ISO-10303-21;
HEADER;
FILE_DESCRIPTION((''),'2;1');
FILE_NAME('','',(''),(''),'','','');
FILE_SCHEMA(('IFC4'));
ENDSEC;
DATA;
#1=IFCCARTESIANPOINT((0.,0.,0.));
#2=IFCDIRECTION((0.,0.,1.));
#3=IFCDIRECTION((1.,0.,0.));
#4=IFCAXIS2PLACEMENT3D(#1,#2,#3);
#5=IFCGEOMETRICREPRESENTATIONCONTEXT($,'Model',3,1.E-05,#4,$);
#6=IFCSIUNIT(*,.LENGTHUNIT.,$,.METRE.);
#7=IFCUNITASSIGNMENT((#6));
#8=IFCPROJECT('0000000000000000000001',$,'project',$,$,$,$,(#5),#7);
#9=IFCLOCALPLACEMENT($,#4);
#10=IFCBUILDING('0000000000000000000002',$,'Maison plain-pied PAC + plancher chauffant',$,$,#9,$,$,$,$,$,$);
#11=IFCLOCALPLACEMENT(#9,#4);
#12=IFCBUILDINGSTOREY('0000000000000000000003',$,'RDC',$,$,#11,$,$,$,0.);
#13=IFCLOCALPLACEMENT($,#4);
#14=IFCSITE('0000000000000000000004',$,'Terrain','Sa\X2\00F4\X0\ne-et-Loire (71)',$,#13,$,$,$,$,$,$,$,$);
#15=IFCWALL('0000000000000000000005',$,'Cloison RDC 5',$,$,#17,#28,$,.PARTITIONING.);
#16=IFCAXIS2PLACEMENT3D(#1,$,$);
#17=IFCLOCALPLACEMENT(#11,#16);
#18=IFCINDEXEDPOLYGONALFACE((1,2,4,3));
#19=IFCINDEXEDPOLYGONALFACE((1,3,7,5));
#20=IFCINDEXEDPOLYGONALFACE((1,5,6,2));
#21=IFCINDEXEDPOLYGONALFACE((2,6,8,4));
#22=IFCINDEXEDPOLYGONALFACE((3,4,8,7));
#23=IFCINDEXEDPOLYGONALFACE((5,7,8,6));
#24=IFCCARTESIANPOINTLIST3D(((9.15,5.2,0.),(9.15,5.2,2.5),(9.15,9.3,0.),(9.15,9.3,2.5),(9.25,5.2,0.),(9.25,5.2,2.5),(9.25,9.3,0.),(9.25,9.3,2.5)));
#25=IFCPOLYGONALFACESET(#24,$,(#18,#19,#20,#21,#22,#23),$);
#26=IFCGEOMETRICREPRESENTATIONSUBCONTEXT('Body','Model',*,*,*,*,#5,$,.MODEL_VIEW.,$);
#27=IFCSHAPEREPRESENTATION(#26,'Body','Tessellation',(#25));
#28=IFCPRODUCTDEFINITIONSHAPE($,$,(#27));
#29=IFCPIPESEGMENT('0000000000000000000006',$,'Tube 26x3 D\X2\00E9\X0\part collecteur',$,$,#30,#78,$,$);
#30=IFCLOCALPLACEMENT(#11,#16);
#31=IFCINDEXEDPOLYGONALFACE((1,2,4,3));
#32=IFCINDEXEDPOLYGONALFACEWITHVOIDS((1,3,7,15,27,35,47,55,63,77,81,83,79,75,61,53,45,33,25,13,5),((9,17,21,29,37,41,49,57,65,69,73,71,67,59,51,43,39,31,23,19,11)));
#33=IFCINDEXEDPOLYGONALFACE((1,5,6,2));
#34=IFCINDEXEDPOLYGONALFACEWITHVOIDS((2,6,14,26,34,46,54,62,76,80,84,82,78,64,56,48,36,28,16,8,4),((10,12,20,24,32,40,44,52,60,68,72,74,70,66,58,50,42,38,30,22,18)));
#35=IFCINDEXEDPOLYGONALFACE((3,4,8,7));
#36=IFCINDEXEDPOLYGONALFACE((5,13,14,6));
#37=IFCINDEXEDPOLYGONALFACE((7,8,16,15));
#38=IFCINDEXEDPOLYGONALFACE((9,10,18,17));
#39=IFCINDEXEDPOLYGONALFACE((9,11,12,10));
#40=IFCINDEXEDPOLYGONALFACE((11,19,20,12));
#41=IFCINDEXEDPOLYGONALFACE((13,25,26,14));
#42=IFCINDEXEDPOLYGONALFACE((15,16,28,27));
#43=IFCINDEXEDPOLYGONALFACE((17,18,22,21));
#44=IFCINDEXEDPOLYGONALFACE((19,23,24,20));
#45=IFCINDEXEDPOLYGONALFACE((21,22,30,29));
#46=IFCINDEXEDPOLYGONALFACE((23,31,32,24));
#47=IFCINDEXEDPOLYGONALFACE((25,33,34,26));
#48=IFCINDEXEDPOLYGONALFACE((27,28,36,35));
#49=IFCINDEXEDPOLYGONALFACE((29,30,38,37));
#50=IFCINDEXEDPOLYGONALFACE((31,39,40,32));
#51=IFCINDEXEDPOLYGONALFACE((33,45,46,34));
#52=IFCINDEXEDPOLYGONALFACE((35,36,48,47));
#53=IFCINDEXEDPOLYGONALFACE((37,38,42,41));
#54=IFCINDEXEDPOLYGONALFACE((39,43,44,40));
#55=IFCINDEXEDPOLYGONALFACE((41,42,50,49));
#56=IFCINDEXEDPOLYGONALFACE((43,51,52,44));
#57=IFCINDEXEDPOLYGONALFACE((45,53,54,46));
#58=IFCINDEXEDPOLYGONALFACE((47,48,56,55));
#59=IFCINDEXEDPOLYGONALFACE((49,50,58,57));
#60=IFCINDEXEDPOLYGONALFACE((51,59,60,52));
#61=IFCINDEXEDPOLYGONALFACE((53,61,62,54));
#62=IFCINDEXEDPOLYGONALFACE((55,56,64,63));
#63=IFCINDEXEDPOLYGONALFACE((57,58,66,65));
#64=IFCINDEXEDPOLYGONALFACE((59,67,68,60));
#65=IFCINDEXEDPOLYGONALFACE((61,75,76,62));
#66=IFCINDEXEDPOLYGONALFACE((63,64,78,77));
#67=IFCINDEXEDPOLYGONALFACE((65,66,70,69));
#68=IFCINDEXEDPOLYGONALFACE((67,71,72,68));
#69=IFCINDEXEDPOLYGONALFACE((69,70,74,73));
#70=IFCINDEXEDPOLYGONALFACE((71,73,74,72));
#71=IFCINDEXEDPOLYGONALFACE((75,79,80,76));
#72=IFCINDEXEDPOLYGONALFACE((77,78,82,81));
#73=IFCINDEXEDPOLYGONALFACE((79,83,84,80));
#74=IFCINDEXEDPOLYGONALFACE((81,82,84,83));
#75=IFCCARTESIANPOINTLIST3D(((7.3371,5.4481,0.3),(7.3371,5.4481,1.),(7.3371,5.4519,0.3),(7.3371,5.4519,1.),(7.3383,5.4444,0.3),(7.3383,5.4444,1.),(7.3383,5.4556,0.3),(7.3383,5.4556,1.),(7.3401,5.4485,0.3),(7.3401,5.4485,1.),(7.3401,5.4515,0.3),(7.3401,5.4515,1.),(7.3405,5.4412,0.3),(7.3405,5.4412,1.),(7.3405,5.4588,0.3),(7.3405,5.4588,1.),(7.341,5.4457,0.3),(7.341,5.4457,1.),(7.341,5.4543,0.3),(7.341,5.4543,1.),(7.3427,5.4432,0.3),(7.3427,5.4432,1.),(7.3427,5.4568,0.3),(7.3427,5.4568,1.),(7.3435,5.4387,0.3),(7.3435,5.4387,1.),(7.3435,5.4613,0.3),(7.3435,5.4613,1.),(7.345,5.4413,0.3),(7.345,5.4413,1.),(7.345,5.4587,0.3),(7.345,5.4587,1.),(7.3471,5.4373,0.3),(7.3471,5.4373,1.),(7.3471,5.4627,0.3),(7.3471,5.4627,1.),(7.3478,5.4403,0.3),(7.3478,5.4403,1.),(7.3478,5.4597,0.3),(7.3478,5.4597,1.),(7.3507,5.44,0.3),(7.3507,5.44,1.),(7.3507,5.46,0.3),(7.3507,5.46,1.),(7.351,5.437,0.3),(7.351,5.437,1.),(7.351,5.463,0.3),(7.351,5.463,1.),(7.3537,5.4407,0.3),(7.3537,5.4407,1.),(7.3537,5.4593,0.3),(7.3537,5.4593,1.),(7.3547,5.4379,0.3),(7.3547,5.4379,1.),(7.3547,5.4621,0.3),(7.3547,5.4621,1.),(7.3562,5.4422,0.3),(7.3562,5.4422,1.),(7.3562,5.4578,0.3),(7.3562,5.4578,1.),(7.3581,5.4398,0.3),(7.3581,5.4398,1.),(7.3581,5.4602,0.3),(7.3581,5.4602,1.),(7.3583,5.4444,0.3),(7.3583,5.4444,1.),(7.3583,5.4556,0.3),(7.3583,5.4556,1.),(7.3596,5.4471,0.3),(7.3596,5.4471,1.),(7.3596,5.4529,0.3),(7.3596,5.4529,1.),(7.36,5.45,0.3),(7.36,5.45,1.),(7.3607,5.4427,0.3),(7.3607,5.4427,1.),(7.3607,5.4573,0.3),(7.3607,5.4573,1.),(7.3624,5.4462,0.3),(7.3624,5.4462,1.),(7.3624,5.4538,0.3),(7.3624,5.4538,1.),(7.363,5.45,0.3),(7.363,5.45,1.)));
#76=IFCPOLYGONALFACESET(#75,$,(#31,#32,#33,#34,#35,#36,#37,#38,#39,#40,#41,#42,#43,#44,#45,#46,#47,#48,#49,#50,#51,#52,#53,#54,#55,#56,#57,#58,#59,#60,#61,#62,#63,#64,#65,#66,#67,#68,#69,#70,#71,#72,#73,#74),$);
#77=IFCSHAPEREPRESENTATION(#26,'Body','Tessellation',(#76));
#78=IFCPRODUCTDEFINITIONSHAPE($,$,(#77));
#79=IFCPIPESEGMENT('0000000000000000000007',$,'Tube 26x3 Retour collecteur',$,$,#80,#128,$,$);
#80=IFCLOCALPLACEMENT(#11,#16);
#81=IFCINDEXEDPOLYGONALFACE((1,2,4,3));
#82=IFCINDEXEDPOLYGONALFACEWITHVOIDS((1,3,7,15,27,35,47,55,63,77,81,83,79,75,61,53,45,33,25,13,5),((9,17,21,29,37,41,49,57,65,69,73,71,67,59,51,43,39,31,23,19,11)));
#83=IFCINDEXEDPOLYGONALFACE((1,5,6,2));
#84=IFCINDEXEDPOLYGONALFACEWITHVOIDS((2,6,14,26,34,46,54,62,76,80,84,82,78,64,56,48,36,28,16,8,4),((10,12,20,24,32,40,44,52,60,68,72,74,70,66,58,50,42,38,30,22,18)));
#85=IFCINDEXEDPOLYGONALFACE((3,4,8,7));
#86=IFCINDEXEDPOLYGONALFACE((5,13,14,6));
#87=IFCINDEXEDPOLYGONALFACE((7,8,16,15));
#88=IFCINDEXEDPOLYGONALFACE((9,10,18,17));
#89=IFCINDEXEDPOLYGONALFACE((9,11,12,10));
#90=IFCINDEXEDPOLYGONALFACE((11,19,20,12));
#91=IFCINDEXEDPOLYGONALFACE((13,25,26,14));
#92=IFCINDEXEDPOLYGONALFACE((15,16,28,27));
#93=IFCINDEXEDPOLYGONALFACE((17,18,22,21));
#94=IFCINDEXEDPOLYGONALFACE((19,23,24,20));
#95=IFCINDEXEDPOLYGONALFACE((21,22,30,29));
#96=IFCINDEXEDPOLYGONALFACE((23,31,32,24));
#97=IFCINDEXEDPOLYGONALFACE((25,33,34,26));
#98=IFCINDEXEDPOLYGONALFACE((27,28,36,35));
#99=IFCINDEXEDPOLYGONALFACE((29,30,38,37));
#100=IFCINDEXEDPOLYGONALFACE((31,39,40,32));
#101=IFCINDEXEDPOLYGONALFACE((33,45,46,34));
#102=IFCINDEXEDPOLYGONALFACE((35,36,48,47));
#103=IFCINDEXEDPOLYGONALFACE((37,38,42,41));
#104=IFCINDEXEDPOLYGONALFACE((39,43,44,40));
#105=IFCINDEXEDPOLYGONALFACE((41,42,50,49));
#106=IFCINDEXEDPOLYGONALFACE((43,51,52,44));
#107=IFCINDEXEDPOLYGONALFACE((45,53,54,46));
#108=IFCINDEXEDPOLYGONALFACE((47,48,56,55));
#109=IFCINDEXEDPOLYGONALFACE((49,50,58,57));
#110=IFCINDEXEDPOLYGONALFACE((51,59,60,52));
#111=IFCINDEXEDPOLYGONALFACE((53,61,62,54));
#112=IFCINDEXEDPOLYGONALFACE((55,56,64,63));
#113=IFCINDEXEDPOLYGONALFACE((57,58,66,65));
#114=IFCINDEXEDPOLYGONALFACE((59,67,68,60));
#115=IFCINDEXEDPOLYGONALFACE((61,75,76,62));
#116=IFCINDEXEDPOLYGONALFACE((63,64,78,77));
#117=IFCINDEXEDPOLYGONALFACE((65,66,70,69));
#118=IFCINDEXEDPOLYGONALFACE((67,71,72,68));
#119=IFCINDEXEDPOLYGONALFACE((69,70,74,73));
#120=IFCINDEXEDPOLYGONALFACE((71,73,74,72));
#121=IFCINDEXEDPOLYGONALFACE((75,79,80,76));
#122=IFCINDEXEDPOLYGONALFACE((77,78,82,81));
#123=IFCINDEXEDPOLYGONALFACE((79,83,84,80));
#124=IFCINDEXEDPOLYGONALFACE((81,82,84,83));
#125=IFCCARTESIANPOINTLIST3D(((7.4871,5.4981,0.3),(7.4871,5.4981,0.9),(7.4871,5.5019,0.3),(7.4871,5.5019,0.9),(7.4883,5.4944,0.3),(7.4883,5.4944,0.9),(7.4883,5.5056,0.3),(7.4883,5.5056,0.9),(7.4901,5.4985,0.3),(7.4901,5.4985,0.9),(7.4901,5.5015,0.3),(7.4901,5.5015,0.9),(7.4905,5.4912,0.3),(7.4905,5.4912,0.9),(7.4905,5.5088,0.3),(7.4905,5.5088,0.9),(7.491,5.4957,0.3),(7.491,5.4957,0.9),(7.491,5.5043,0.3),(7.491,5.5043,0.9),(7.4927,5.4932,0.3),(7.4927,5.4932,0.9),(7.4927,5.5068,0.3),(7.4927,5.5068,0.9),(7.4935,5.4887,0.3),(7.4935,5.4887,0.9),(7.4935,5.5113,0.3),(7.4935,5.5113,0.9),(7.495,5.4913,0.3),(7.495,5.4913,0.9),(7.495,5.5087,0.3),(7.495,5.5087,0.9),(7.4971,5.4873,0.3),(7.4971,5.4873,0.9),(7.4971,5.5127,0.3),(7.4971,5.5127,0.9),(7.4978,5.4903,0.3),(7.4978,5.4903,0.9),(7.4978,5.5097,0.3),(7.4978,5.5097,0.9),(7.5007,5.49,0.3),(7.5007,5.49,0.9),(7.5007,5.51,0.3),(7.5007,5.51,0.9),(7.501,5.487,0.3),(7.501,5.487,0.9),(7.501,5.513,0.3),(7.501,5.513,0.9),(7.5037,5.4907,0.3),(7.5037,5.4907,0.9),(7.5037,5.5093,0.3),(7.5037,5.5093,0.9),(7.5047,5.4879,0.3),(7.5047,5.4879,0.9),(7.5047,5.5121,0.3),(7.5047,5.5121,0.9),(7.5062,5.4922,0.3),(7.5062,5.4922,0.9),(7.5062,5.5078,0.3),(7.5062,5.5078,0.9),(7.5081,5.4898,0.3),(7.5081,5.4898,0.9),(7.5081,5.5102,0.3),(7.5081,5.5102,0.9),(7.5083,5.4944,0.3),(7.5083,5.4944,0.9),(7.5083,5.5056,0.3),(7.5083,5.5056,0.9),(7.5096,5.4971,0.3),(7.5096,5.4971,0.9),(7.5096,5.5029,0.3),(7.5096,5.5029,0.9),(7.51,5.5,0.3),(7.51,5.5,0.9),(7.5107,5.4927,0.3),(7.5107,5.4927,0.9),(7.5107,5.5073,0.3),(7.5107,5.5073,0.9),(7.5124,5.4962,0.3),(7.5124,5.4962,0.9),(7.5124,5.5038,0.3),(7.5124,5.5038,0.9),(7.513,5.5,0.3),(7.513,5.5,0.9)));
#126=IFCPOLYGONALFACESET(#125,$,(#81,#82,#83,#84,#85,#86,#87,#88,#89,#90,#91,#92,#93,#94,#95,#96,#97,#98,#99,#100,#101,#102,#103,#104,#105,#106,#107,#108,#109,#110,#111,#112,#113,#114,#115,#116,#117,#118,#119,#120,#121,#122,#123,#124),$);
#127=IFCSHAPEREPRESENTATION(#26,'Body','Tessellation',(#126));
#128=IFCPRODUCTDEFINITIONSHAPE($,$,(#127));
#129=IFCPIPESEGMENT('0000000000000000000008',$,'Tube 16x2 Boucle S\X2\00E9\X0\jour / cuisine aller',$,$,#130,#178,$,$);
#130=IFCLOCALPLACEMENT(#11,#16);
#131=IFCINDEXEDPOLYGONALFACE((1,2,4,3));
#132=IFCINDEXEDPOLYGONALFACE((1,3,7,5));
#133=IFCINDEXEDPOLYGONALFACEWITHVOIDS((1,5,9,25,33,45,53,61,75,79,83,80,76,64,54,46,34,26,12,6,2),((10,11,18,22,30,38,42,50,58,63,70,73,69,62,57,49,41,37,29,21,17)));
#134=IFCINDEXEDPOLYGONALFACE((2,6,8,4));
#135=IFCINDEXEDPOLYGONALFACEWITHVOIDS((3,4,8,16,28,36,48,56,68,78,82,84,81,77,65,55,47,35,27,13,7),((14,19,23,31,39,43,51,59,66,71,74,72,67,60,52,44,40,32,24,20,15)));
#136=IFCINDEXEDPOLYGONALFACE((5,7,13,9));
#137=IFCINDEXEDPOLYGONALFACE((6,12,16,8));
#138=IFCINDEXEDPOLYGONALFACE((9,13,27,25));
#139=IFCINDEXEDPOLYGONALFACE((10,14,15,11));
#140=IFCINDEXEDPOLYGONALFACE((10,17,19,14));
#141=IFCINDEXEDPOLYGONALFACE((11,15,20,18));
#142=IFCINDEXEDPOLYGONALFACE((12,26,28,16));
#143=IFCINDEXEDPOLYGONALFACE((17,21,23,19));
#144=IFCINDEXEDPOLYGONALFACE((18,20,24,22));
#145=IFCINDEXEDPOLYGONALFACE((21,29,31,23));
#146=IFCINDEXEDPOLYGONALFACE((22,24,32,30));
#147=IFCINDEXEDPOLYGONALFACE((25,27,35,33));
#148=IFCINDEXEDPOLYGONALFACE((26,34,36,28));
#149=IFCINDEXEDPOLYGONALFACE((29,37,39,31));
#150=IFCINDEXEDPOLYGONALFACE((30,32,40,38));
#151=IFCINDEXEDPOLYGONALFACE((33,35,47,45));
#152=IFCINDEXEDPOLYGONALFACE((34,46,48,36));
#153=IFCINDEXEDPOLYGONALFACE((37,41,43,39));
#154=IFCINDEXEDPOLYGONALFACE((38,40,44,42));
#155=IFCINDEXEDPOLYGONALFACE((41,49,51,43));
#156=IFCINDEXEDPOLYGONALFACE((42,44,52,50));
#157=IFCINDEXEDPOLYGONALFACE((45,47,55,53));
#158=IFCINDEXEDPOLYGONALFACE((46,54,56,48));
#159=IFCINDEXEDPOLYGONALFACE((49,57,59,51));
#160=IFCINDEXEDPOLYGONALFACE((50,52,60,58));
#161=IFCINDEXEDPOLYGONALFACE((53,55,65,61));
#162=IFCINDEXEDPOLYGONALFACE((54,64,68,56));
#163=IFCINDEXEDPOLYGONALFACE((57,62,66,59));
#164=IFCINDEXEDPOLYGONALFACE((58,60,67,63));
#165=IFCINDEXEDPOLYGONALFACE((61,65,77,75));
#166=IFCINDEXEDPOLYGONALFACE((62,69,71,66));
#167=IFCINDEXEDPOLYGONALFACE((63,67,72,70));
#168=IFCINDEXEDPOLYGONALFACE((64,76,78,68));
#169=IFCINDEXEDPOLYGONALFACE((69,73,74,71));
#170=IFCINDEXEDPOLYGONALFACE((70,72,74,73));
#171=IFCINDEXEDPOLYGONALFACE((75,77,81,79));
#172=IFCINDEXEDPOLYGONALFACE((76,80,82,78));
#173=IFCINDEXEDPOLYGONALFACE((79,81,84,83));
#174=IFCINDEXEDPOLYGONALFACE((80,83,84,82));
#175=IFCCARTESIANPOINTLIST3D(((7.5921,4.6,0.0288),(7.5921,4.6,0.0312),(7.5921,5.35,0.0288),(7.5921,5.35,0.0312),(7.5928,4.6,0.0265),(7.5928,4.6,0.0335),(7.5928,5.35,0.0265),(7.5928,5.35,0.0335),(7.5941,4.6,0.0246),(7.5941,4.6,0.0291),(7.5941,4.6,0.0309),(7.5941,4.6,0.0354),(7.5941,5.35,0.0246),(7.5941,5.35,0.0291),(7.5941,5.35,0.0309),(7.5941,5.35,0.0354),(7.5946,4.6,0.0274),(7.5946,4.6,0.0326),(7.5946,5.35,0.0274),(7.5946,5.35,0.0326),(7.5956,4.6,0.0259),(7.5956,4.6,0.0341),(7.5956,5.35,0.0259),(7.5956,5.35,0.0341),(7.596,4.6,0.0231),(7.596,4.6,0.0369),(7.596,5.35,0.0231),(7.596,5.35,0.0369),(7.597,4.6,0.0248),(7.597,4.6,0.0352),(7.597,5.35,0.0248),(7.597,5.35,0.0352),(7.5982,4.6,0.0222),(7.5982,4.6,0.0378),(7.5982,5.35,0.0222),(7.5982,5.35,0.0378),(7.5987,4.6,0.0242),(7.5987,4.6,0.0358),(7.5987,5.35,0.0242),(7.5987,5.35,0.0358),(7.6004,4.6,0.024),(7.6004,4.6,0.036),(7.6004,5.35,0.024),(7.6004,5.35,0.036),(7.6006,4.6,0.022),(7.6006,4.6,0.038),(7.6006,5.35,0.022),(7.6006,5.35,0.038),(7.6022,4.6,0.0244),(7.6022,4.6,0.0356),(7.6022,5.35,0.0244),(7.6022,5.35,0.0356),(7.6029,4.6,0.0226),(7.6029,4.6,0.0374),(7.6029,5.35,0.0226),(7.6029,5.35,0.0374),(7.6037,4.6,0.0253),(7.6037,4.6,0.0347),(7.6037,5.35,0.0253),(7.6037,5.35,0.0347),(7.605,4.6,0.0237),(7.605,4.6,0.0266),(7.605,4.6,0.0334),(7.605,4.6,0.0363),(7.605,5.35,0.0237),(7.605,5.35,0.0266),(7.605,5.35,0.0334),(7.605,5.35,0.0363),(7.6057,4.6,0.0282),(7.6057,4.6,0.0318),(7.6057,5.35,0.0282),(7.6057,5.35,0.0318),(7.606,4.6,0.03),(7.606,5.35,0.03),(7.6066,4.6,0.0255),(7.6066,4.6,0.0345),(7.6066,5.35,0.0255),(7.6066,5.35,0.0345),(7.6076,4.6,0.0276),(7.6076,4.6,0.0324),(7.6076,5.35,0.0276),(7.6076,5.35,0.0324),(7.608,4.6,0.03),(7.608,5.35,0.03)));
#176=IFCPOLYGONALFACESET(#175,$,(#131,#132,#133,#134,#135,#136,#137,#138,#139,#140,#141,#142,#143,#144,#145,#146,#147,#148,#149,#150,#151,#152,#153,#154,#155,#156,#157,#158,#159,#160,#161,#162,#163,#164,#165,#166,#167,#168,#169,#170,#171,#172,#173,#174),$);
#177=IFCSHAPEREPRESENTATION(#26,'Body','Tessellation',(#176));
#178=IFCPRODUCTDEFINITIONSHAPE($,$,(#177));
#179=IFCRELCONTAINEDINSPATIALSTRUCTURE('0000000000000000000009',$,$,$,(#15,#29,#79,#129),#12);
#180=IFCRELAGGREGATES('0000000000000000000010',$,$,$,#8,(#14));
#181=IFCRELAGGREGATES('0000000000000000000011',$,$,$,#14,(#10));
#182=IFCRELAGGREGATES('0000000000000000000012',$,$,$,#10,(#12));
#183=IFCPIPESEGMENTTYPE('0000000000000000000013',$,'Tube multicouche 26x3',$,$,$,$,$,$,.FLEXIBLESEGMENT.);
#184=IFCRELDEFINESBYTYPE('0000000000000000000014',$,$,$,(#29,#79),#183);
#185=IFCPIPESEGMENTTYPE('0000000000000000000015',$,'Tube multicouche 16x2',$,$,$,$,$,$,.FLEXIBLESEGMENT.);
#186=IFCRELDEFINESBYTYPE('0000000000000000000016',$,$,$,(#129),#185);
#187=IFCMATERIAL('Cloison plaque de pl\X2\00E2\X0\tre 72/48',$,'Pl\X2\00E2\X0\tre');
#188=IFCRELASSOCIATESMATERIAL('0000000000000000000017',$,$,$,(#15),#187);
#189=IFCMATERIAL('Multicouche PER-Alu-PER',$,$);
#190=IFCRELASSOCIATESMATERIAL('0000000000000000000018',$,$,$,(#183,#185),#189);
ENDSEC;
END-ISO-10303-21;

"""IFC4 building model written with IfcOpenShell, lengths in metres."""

from ifc_helpers import new_model, si_unit, frame, frame_2d, origin_with_axes, place, context, subcontext, project, spatial, rectangle, hollow_circle, extrude, material, type_object, element, save


model = new_model("IFC4")

# Units and contexts
model_context = context("Model", 3, precision=1e-05, world=origin_with_axes())
body_context = subcontext(model_context, "Body", "Model", "MODEL_VIEW")
ifc_project = project(units=[si_unit("LENGTHUNIT", "METRE")], contexts=[model_context])

# Site, building, storey
site_placement = place(None, origin_with_axes())
site = spatial("IfcSite", under=ifc_project, at=site_placement, Name="Terrain", Description="Saône-et-Loire (71)")
building_placement = place(None, origin_with_axes())
building = spatial("IfcBuilding", under=site, at=building_placement, Name="Maison plain-pied PAC + plancher chauffant")
storey_placement = place(building_placement, origin_with_axes())
storey = spatial("IfcBuildingStorey", under=building, at=storey_placement, Name="RDC", Elevation=0.0)

# Wall
ifc_material_1 = material(Name="Cloison plaque de plâtre 72/48", Category="Plâtre")
wall_placement = place(storey_placement, frame((9.15, 5.2, 0.0), z_axis=(0.0, 0.0, 1.0), x_axis=(1.0, 0.0, 0.0)))
element("IfcWall", 1, at=wall_placement, inside=storey, material=ifc_material_1, Name="Cloison RDC 5", PredefinedType="PARTITIONING", context=body_context, shape_type="SweptSolid", body=[
    extrude(rectangle(XDim=0.1, YDim=4.1, at=frame_2d((0.05, 2.05))), origin_with_axes(), (0.0, 0.0, 1.0), 2.5),
])

# Pipe segments
ifc_material_2 = material(Name="Multicouche PER-Alu-PER")
pipe_segment_type_1 = type_object("IfcPipeSegmentType", Name="Tube multicouche 26x3", PredefinedType="FLEXIBLESEGMENT", material=ifc_material_2)
pipe_segment_1_placement = place(storey_placement, frame((7.35, 5.45, 1.0), z_axis=(0.0, 0.0, -1.0), x_axis=(1.0, 0.0, 0.0)))
element("IfcPipeSegment", 2, at=pipe_segment_1_placement, inside=storey, type_object=pipe_segment_type_1, Name="Tube 26x3 Départ collecteur", context=body_context, shape_type="SweptSolid", body=[
    extrude(hollow_circle(Radius=0.013, WallThickness=0.003), origin_with_axes(), (0.0, 0.0, 1.0), 0.7),
])
pipe_segment_2_placement = place(storey_placement, frame((7.5, 5.5, 0.9), z_axis=(0.0, 0.0, -1.0), x_axis=(1.0, 0.0, 0.0)))
element("IfcPipeSegment", 3, at=pipe_segment_2_placement, inside=storey, type_object=pipe_segment_type_1, Name="Tube 26x3 Retour collecteur", context=body_context, shape_type="SweptSolid", body=[
    extrude(hollow_circle(Radius=0.013, WallThickness=0.003), origin_with_axes(), (0.0, 0.0, 1.0), 0.6),
])
pipe_segment_type_2 = type_object("IfcPipeSegmentType", Name="Tube multicouche 16x2", PredefinedType="FLEXIBLESEGMENT", material=ifc_material_2)
pipe_segment_3_placement = place(storey_placement, frame((7.6, 5.35, 0.03), z_axis=(0.0, -1.0, 0.0), x_axis=(1.0, 0.0, 0.0)))
element("IfcPipeSegment", 4, at=pipe_segment_3_placement, inside=storey, type_object=pipe_segment_type_2, Name="Tube 16x2 Boucle Séjour / cuisine aller", context=body_context, shape_type="SweptSolid", body=[
    extrude(hollow_circle(Radius=0.008, WallThickness=0.002), origin_with_axes(), (0.0, 0.0, 1.0), 0.75),
])

save(model, "model.ifc")
